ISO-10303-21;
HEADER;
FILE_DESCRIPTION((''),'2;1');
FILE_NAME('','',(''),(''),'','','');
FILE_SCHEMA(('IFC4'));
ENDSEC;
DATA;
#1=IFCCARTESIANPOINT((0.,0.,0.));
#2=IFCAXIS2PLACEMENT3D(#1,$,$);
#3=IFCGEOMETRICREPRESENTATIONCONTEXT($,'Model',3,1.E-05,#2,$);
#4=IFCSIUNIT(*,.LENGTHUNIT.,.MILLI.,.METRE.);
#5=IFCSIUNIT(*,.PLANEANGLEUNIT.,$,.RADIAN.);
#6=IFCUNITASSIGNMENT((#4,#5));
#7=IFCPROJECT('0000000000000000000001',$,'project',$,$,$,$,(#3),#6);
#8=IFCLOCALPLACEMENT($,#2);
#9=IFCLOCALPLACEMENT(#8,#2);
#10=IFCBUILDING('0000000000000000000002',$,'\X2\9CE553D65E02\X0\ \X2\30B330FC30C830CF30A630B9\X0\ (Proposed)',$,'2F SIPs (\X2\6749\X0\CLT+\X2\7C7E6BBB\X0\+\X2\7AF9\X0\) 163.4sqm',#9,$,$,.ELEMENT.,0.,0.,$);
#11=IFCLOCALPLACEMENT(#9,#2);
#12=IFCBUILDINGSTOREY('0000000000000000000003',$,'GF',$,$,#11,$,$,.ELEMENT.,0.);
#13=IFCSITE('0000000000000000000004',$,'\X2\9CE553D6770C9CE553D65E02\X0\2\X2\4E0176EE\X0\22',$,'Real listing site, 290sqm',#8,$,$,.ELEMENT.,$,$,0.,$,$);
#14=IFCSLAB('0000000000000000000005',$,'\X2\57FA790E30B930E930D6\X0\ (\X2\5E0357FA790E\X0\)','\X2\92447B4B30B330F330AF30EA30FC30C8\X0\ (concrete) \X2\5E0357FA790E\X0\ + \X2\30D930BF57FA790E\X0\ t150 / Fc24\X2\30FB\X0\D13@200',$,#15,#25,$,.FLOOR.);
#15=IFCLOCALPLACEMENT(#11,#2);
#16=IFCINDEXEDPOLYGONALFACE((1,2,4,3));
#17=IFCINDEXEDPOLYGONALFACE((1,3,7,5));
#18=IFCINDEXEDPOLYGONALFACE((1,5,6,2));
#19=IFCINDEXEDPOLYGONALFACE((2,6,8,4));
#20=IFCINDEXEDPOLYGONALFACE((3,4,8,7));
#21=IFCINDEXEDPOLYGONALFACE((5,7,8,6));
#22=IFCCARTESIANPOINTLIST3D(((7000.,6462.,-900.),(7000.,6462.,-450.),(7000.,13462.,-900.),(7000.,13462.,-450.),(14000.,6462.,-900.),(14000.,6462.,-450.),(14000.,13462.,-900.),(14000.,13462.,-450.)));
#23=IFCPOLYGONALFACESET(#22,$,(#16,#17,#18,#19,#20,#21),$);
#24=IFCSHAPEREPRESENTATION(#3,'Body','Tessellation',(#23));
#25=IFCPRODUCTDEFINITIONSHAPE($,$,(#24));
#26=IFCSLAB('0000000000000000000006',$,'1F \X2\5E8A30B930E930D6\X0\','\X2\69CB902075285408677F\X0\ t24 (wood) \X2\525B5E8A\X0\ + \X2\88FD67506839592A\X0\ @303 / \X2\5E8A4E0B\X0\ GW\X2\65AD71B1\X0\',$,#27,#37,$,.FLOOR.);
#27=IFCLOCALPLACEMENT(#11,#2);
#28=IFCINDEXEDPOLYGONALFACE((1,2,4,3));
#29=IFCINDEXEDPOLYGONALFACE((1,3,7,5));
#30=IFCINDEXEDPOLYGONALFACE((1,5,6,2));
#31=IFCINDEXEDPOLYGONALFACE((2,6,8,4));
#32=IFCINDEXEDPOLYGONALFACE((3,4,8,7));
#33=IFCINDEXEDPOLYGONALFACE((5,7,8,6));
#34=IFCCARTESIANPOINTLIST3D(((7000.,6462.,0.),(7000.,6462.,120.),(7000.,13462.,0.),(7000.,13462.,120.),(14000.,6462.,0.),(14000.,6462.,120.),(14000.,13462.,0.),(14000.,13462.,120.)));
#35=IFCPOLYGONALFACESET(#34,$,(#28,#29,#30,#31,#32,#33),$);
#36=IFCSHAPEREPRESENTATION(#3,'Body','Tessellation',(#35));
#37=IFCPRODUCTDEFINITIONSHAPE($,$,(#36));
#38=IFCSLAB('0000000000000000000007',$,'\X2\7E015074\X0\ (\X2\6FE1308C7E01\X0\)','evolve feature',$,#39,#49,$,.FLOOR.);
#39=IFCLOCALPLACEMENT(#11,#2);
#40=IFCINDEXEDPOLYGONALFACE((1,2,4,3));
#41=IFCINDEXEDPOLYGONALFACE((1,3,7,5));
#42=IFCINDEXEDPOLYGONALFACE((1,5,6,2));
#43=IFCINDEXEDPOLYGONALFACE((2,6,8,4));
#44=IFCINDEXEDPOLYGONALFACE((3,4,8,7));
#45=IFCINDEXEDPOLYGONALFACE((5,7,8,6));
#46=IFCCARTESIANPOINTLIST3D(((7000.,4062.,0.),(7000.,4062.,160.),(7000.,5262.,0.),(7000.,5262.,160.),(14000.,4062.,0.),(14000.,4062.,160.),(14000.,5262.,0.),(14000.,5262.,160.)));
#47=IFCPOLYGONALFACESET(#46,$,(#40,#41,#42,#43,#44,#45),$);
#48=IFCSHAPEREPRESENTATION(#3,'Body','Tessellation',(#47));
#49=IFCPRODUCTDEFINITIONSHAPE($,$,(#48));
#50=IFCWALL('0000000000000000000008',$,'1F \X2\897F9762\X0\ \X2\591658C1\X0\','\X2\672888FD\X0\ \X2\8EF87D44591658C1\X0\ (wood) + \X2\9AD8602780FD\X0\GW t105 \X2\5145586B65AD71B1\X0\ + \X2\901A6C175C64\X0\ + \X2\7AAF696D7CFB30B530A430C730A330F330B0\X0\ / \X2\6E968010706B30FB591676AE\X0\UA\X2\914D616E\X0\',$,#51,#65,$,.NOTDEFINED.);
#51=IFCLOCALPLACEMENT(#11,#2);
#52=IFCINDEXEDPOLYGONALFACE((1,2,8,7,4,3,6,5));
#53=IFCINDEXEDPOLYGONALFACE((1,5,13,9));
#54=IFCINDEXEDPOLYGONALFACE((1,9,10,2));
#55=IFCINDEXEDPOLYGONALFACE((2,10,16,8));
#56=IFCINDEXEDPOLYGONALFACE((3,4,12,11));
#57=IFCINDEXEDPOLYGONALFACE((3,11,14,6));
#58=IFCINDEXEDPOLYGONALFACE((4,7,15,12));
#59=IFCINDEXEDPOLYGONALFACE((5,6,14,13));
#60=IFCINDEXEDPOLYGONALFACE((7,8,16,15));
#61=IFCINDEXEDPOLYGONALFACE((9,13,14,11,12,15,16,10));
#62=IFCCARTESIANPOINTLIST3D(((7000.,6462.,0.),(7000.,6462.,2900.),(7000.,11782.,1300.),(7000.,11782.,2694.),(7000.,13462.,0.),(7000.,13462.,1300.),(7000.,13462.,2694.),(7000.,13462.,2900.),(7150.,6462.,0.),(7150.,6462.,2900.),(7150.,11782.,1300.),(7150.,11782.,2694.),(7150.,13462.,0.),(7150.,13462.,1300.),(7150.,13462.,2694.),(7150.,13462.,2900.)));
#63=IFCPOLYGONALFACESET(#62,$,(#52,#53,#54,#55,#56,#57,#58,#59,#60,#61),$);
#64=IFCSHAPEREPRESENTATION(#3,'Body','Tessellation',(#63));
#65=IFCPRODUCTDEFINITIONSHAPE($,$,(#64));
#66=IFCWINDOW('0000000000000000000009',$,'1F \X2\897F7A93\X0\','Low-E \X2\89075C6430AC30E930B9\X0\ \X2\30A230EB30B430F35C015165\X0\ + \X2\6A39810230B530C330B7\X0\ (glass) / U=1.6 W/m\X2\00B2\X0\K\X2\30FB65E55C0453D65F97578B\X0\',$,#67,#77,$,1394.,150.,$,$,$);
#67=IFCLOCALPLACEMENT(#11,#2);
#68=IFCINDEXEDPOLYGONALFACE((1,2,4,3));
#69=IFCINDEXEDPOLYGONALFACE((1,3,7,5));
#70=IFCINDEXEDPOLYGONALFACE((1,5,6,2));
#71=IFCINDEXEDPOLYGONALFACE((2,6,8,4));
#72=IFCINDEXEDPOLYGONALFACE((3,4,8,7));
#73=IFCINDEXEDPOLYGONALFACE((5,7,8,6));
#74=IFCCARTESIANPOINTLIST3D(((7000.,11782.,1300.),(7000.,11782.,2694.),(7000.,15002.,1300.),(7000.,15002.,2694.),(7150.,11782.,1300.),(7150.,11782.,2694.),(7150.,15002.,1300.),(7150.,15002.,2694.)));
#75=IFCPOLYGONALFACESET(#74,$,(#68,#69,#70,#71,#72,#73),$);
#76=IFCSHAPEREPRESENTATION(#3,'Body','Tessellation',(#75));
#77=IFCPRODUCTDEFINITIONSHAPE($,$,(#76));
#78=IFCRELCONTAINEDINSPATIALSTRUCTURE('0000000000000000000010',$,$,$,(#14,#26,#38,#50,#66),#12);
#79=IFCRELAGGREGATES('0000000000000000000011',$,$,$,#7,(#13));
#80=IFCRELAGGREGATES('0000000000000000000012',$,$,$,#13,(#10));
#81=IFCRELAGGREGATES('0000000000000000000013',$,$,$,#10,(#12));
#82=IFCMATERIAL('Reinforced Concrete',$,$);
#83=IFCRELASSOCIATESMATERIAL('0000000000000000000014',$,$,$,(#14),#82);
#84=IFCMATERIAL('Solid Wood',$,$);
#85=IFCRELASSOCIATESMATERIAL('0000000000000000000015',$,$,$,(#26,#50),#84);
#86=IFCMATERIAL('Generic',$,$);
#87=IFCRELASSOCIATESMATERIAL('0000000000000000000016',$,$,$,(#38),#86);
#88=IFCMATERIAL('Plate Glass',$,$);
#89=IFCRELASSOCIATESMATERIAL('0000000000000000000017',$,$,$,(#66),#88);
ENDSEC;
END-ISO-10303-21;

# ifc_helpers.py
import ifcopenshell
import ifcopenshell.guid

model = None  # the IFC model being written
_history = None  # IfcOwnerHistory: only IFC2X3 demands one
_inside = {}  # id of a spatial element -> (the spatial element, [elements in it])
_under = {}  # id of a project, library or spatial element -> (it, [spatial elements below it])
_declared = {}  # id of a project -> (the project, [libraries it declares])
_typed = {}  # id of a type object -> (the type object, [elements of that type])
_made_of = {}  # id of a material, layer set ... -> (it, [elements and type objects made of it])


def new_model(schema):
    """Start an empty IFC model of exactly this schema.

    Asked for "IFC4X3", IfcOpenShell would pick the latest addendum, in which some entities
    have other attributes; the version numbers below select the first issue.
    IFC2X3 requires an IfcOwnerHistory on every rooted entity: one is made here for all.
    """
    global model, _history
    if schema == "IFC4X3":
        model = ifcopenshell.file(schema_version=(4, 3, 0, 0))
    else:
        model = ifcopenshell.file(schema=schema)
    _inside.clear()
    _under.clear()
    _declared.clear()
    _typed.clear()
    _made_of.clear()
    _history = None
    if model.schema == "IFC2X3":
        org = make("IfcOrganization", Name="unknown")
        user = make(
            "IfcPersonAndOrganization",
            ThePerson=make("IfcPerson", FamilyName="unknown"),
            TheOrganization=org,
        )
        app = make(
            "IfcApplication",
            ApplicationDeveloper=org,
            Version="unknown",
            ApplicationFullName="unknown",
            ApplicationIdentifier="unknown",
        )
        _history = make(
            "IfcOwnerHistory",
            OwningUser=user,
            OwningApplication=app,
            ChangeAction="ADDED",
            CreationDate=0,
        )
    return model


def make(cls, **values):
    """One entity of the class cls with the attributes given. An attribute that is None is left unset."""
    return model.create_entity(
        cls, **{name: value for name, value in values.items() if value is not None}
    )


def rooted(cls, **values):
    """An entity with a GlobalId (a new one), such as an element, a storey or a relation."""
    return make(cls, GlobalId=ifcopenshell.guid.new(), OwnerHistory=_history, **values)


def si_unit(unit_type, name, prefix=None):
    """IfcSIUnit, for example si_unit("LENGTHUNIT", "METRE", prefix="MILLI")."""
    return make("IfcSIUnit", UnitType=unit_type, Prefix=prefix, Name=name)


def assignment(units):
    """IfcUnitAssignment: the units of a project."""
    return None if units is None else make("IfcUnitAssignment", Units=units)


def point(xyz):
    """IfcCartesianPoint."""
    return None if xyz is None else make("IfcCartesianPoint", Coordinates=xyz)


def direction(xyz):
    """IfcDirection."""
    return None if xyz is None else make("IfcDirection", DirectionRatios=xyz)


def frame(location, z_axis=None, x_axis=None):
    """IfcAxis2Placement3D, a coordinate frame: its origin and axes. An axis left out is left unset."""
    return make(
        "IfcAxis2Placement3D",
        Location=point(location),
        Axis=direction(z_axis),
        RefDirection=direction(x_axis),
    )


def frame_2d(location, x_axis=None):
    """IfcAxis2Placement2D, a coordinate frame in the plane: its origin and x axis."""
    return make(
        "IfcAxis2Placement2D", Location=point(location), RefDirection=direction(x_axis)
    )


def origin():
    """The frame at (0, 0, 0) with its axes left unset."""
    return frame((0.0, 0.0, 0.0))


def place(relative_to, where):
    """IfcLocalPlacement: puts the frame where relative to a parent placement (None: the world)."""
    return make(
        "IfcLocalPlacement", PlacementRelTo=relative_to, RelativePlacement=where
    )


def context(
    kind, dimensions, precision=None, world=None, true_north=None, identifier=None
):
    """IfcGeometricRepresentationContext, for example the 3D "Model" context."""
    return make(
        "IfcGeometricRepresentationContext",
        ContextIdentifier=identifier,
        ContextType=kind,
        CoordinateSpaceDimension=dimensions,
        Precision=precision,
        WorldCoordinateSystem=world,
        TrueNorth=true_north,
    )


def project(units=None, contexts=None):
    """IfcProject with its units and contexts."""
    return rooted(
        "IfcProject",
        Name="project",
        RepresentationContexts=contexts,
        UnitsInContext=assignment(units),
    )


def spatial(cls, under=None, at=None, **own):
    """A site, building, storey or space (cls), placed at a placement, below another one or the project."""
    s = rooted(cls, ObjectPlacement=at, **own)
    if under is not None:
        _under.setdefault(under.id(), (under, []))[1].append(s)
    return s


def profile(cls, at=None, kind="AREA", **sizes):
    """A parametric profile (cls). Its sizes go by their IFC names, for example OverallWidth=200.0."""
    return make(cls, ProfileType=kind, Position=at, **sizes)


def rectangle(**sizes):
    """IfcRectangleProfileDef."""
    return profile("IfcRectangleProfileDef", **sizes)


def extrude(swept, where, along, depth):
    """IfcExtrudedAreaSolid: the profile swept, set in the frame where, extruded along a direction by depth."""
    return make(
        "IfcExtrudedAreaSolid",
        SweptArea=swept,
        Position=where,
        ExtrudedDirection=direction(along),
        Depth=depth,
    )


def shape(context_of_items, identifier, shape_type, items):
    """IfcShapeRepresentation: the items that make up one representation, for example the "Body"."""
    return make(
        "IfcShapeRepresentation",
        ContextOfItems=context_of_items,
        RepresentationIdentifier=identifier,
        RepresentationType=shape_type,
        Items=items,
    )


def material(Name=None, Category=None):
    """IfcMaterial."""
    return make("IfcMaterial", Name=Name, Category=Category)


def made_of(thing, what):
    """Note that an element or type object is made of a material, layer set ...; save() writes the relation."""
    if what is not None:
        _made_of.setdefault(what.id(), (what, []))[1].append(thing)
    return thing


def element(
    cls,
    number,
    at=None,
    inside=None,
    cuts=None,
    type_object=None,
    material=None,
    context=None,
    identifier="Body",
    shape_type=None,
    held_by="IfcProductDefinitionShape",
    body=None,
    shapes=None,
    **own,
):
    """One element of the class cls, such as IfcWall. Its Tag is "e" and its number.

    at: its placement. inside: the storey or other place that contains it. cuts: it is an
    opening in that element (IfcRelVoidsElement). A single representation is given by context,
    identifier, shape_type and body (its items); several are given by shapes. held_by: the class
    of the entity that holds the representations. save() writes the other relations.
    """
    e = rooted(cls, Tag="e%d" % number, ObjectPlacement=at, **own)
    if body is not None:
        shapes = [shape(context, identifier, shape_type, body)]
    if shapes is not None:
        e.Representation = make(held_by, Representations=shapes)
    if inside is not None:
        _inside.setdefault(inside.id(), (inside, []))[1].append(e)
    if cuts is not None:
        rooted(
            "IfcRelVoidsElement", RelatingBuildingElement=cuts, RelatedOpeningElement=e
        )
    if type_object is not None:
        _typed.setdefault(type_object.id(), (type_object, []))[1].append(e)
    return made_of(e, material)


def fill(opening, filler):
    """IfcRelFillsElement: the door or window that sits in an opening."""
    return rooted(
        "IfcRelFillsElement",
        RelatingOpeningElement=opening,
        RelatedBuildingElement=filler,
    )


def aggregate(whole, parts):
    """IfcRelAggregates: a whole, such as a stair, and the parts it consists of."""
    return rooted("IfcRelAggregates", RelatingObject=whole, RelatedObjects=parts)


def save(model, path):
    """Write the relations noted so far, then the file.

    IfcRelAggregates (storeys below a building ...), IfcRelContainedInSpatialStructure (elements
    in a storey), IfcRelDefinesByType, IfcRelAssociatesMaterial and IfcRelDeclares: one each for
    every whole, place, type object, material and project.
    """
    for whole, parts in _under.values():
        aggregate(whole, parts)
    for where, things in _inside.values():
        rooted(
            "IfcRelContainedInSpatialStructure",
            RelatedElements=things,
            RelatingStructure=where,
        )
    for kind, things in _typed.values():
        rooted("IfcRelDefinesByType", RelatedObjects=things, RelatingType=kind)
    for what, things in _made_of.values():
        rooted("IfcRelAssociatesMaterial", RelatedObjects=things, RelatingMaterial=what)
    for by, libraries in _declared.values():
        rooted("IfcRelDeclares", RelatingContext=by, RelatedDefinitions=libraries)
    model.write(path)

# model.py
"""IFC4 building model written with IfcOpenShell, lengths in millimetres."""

from ifc_helpers import new_model, si_unit, frame, frame_2d, origin, place, context, project, spatial, rectangle, extrude, material, element, fill, save


model = new_model("IFC4")

# Units and contexts
model_context = context("Model", 3, precision=1e-05, world=origin())
ifc_project = project(units=[si_unit("LENGTHUNIT", "METRE", prefix="MILLI"), si_unit("PLANEANGLEUNIT", "RADIAN")], contexts=[model_context])

# Site, building, storey
site_placement = place(None, origin())
site = spatial("IfcSite", under=ifc_project, at=site_placement, Name="鳥取県鳥取市2丁目22", ObjectType="Real listing site, 290sqm", CompositionType="ELEMENT", RefElevation=0.0)
building_placement = place(site_placement, origin())
building = spatial("IfcBuilding", under=site, at=building_placement, Name="鳥取市 コートハウス (Proposed)", ObjectType="2F SIPs (杉CLT+籾殻+竹) 163.4sqm", CompositionType="ELEMENT", ElevationOfRefHeight=0.0, ElevationOfTerrain=0.0)
storey_placement = place(building_placement, origin())
storey = spatial("IfcBuildingStorey", under=building, at=storey_placement, Name="GF", CompositionType="ELEMENT", Elevation=0.0)

# Slabs
ifc_material_1 = material(Name="Reinforced Concrete")
slab_1_placement = place(storey_placement, frame((3500.0, 3231.0, -450.0)))
element("IfcSlab", 1, at=slab_1_placement, inside=storey, material=ifc_material_1, Name="基礎スラブ (布基礎)", Description="鉄筋コンクリート (concrete) 布基礎 + ベタ基礎 t150 / Fc24・D13@200", PredefinedType="FLOOR", context=model_context, shape_type="SweptSolid", body=[
    extrude(rectangle(XDim=7000.0, YDim=7000.0, at=frame_2d((3500.0, 3500.0))), frame((3500.0, 3231.0, -450.0)), (0.0, 0.0, 1.0), 450.0),
])
ifc_material_2 = material(Name="Solid Wood")
slab_2_placement = place(storey_placement, frame((3500.0, 3231.0, 0.0)))
element("IfcSlab", 2, at=slab_2_placement, inside=storey, material=ifc_material_2, Name="1F 床スラブ", Description="構造用合板 t24 (wood) 剛床 + 製材根太 @303 / 床下 GW断熱", PredefinedType="FLOOR", context=model_context, shape_type="SweptSolid", body=[
    extrude(rectangle(XDim=7000.0, YDim=7000.0, at=frame_2d((3500.0, 3500.0))), frame((3500.0, 3231.0, 0.0)), (0.0, 0.0, 1.0), 120.0),
])
ifc_material_3 = material(Name="Generic")
slab_3_placement = place(storey_placement, frame((3500.0, 2031.0, 0.0)))
element("IfcSlab", 3, at=slab_3_placement, inside=storey, material=ifc_material_3, Name="縁側 (濡れ縁)", Description="evolve feature", PredefinedType="FLOOR", context=model_context, shape_type="SweptSolid", body=[
    extrude(rectangle(XDim=7000.0, YDim=1200.0, at=frame_2d((3500.0, 600.0))), frame((3500.0, 2031.0, 0.0)), (0.0, 0.0, 1.0), 160.0),
])

# Shared definitions
ifc_material_4 = material(Name="Plate Glass")

# Wall, opening, window
wall_1_placement = place(storey_placement, frame((3500.0, 3231.0, 0.0)))
wall_1 = element("IfcWall", 4, at=wall_1_placement, inside=storey, material=ifc_material_2, Name="1F 西面 外壁", Description="木製 軸組外壁 (wood) + 高性能GW t105 充填断熱 + 通気層 + 窯業系サイディング / 準耐火・外皮UA配慮", PredefinedType="NOTDEFINED", context=model_context, shape_type="SweptSolid", body=[
    extrude(rectangle(XDim=150.0, YDim=7000.0, at=frame_2d((75.0, 3500.0))), frame((3500.0, 3231.0, 0.0)), (0.0, 0.0, 1.0), 2900.0),
])
opening_1_placement = place(storey_placement, frame((3500.0, 5891.0, 650.0)))
opening_1 = element("IfcOpeningElement", 5, at=opening_1_placement, cuts=wall_1, PredefinedType="NOTDEFINED", context=model_context, shape_type="SweptSolid", body=[
    extrude(rectangle(XDim=150.0, YDim=3220.0, at=frame_2d((75.0, 1610.0))), frame((3500.0, 5891.0, 650.0)), (0.0, 0.0, 1.0), 1394.0),
])
window_1_placement = place(storey_placement, frame((3500.0, 5891.0, 650.0)))
window_1 = element("IfcWindow", 6, at=window_1_placement, inside=storey, material=ifc_material_4, Name="1F 西窓", Description="Low-E 複層ガラス アルゴン封入 + 樹脂サッシ (glass) / U=1.6 W/m²K・日射取得型", OverallHeight=1394.0, OverallWidth=150.0, context=model_context, shape_type="SweptSolid", body=[
    extrude(rectangle(XDim=150.0, YDim=3220.0, at=frame_2d((75.0, 1610.0))), frame((3500.0, 5891.0, 650.0)), (0.0, 0.0, 1.0), 1394.0),
])
fill(opening_1, window_1)

save(model, "model.ifc")
